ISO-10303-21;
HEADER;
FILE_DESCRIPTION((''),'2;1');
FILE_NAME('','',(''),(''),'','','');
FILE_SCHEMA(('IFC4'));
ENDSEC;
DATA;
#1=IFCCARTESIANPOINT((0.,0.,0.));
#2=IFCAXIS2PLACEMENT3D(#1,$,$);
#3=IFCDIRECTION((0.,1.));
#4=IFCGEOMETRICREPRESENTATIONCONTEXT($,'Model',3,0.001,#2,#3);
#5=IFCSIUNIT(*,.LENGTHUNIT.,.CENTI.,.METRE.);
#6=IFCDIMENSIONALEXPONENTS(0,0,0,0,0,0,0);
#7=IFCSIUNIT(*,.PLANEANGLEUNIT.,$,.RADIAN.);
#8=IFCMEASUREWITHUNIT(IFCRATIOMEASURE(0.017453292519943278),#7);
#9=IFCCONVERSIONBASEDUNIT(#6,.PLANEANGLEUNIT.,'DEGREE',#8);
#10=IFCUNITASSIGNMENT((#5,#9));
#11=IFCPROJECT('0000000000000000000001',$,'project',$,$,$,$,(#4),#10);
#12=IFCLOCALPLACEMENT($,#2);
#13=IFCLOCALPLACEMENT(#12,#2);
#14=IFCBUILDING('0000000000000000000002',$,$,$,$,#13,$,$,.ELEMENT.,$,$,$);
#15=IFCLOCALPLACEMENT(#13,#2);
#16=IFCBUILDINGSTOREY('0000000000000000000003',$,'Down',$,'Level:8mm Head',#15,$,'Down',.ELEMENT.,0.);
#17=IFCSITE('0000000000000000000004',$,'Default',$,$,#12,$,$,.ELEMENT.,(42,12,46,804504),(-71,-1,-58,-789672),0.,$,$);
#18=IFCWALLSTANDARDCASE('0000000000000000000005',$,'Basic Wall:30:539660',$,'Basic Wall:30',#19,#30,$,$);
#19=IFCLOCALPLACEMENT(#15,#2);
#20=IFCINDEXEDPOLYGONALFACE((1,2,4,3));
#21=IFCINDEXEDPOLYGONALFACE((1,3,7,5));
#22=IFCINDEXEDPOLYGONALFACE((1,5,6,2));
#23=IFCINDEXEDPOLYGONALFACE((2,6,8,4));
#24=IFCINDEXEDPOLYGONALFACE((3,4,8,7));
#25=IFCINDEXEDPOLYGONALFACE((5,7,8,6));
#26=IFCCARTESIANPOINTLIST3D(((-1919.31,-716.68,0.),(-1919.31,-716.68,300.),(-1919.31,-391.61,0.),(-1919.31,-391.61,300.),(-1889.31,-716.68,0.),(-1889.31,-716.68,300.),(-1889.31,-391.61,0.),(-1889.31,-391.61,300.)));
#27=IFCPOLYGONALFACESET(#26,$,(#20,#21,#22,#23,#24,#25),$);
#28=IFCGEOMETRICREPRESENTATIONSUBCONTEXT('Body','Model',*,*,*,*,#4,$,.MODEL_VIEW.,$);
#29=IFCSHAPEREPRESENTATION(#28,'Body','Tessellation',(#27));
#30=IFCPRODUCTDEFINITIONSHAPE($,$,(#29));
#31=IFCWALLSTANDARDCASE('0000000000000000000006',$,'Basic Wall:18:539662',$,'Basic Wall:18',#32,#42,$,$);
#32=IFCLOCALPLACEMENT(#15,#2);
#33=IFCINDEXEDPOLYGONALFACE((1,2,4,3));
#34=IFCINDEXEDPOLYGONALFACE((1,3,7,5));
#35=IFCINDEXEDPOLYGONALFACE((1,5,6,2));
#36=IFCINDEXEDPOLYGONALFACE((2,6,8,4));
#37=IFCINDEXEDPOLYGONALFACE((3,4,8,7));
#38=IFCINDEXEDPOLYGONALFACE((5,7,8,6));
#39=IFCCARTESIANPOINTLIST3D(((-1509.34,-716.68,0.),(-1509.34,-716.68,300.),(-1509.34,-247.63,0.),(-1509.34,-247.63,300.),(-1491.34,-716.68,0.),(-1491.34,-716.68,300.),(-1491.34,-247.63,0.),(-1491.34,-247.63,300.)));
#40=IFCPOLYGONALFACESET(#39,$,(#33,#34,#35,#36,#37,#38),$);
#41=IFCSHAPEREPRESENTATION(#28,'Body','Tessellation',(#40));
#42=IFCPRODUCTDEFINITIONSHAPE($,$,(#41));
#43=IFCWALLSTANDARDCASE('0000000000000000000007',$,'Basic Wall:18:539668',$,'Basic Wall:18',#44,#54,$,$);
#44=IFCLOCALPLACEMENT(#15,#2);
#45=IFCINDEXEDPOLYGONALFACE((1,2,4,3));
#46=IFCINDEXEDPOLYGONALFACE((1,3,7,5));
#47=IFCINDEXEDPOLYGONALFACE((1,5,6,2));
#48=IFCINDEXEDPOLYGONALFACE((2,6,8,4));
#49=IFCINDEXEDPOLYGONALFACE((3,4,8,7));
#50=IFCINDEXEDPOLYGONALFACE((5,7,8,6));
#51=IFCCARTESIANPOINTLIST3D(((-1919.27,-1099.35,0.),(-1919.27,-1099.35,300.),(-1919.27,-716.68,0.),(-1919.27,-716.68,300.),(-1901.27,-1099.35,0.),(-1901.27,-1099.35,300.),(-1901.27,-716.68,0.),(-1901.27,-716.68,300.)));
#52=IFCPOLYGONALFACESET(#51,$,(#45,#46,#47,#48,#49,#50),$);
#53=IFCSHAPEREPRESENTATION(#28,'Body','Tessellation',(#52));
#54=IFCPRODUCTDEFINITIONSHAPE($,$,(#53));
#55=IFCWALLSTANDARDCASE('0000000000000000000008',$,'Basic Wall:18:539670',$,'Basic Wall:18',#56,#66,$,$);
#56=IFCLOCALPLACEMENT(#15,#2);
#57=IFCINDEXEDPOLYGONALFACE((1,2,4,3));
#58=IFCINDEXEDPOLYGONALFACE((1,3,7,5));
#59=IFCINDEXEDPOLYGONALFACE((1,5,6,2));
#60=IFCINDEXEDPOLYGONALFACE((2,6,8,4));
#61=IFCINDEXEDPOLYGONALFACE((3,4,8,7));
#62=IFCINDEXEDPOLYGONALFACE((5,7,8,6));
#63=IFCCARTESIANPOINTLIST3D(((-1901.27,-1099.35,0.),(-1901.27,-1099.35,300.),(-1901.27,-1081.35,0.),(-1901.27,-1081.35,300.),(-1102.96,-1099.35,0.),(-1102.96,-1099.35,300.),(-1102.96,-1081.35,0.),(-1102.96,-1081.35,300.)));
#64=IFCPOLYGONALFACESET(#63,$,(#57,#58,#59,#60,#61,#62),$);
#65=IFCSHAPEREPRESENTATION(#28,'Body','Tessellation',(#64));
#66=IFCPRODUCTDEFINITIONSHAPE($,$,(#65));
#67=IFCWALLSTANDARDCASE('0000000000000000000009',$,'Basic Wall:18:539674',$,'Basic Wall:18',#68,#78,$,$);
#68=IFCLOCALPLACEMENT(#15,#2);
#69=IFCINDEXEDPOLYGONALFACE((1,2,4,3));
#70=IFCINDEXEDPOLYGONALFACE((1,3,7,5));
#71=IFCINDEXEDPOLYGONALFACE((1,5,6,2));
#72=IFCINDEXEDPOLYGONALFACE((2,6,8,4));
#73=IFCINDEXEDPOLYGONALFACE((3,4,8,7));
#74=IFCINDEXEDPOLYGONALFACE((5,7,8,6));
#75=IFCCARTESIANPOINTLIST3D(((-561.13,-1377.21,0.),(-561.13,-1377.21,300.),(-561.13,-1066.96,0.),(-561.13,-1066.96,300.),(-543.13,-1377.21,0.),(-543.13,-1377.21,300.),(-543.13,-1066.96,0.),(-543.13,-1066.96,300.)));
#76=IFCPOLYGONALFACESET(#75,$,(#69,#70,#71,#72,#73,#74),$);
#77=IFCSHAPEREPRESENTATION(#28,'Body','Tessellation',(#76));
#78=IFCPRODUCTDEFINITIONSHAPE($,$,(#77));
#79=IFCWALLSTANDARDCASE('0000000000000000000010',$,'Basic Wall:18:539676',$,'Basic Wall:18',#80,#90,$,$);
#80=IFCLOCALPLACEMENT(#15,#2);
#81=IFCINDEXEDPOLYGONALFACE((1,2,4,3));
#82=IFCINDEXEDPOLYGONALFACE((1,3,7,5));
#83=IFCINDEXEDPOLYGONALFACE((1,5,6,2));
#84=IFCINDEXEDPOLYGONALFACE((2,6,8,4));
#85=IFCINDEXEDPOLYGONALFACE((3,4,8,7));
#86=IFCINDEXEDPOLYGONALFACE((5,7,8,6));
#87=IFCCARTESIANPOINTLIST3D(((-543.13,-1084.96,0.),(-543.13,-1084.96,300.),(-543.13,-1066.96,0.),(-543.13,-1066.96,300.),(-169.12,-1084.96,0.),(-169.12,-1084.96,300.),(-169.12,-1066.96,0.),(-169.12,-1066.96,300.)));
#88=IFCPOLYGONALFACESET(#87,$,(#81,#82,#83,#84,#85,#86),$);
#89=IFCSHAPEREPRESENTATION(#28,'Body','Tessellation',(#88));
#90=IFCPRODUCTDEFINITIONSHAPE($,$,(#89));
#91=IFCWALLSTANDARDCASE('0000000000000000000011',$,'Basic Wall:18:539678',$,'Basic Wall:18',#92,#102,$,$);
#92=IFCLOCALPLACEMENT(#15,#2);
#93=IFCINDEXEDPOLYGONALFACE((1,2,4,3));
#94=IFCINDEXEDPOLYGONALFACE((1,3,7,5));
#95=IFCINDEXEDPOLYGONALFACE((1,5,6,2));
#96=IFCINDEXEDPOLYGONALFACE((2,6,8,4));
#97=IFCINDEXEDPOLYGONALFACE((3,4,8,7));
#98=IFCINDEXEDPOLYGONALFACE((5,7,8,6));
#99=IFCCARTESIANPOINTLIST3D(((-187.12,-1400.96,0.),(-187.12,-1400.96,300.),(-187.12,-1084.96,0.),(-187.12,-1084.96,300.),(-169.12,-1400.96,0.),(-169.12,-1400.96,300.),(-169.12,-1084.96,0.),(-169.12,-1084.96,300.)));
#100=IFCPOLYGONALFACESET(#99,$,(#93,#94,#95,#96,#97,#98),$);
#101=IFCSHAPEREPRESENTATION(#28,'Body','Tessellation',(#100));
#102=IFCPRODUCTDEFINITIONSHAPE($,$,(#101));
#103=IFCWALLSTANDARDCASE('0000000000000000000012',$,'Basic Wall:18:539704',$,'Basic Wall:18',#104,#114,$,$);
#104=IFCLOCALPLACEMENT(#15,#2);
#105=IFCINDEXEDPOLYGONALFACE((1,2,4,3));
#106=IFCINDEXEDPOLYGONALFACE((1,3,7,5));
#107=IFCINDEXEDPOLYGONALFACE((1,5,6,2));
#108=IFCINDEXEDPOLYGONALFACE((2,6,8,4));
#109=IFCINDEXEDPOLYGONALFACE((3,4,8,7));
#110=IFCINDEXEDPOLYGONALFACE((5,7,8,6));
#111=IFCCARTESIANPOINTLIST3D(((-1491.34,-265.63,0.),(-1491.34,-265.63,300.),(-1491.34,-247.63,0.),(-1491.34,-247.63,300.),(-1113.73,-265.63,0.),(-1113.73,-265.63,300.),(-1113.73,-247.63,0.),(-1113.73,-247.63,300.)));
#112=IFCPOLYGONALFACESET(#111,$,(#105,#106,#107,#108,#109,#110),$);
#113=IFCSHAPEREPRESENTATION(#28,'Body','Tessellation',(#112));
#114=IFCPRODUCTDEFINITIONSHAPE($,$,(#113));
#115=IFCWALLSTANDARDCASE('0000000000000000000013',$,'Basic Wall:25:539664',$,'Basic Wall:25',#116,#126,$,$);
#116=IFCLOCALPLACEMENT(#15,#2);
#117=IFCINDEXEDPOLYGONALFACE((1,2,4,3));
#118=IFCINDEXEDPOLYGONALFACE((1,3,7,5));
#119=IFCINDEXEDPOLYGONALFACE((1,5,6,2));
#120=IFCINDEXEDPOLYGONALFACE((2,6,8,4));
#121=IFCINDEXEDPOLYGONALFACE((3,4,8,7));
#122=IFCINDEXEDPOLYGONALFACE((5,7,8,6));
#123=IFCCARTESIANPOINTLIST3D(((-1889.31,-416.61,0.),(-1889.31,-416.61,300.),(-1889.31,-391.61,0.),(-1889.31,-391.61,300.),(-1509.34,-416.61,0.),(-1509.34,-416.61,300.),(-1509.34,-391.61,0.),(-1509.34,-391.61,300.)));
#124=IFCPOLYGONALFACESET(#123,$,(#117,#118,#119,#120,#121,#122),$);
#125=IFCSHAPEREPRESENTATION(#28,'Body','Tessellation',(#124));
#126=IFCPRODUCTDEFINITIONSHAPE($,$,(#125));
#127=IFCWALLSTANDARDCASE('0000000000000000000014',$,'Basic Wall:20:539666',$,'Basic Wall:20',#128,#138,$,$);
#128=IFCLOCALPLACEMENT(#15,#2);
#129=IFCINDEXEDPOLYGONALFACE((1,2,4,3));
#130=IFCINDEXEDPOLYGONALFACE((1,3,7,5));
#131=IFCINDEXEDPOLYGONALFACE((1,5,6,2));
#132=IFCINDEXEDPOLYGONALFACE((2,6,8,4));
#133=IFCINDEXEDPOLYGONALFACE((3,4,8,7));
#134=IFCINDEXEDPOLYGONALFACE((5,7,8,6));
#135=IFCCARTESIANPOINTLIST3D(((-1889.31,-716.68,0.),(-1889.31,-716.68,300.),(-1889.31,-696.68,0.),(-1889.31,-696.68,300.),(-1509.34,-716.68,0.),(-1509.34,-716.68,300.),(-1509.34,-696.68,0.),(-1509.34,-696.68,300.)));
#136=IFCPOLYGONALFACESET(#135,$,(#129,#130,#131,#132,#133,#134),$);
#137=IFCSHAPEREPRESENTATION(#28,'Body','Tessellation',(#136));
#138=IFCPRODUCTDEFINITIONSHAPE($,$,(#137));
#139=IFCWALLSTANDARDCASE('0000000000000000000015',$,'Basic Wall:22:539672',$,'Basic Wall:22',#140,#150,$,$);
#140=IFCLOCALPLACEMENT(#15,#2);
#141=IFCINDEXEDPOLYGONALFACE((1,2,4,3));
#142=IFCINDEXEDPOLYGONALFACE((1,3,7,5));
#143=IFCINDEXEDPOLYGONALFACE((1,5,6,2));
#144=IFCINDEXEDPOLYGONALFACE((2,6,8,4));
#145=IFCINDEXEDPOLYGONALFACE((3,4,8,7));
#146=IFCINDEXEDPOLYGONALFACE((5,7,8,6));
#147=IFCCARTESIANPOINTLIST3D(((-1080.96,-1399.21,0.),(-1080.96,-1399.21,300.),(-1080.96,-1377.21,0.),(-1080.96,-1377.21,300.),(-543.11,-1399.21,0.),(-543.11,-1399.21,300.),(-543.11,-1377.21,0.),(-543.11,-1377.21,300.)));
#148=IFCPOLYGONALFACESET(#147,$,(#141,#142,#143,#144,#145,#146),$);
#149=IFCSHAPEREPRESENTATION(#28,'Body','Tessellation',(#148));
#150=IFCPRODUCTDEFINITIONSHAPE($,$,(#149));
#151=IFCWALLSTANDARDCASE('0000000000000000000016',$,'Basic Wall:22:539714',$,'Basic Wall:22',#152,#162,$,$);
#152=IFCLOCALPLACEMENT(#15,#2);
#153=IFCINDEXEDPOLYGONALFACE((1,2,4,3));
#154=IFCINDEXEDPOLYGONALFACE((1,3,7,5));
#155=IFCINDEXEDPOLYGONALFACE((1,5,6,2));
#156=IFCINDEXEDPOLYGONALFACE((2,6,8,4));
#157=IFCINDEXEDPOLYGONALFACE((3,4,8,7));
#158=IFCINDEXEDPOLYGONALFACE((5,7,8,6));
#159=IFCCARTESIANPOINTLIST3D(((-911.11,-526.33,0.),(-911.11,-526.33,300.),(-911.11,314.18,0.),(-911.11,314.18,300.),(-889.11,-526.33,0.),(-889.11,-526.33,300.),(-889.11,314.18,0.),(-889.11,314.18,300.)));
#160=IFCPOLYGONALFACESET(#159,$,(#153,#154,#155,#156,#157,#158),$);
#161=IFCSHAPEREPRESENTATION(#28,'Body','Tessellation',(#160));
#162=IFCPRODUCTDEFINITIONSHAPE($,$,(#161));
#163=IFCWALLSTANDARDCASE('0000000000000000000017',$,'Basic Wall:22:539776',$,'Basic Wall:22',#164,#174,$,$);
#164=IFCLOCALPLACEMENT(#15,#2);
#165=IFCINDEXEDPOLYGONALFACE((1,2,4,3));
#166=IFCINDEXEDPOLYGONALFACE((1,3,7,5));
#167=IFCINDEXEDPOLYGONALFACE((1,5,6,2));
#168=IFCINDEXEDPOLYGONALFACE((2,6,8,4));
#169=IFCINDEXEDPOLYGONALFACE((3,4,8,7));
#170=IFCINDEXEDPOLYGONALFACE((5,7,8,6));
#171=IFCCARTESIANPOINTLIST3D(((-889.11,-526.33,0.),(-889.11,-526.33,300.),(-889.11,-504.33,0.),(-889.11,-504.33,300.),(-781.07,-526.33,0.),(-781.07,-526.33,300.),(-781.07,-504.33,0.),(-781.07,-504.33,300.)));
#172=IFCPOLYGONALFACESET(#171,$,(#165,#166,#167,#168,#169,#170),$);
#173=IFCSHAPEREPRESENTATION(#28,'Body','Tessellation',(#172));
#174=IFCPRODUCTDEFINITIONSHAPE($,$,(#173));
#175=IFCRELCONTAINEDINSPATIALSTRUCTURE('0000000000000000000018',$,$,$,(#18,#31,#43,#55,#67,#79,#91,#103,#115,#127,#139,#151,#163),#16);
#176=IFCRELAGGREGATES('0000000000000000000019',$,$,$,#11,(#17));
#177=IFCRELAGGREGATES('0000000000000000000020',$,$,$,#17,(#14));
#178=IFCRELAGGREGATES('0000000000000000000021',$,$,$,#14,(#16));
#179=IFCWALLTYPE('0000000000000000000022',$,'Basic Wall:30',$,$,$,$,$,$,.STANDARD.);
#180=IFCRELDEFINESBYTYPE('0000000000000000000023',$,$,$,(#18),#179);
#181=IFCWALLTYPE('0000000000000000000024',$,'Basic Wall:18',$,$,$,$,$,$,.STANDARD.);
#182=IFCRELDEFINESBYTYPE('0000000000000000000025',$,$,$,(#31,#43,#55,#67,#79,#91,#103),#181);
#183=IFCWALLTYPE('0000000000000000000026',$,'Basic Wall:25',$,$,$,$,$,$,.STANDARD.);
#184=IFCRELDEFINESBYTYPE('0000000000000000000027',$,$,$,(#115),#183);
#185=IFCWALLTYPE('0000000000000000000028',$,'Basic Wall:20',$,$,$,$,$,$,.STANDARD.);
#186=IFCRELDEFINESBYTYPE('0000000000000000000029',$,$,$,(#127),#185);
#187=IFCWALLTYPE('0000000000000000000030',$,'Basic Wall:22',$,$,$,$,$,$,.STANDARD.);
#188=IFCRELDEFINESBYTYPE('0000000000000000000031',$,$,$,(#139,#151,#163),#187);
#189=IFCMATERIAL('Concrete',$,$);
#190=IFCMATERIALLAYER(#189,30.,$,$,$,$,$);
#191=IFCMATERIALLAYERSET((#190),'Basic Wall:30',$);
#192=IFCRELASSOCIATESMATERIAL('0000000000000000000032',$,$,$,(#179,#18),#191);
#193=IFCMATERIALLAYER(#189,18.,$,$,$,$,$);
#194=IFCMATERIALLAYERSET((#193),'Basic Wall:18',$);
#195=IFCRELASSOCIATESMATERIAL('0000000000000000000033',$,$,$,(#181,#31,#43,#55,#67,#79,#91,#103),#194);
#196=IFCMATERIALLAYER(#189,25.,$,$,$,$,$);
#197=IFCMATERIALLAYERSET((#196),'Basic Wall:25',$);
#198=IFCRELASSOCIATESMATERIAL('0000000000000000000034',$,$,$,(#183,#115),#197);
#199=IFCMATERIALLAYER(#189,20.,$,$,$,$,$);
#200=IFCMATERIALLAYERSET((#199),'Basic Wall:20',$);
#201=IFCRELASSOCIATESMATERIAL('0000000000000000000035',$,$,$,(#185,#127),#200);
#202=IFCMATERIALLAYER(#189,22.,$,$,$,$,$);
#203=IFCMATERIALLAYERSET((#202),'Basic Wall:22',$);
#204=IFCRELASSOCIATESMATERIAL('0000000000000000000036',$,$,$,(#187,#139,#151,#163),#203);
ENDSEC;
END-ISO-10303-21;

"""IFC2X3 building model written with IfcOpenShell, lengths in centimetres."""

from ifc_helpers import new_model, entity, si_unit, converted_unit, direction, frame, frame_2d, origin, place, context, subcontext, project, spatial, rectangle, extrude, material, layer, layer_set, layer_usage, type_object, element, save


model = new_model("IFC2X3")

# Units and contexts
model_context = context("Model", 3, precision=0.001, world=origin(), true_north=direction((0.0, 1.0)))
body_context = subcontext(model_context, "Body", "Model", "MODEL_VIEW")
ifc_project = project(units=[si_unit("LENGTHUNIT", "METRE", prefix="CENTI"), converted_unit("PLANEANGLEUNIT", "DEGREE", entity("IfcRatioMeasure", 0.017453292519943278), si_unit("PLANEANGLEUNIT", "RADIAN"), dimensions=[0, 0, 0, 0, 0, 0, 0])], contexts=[model_context])

# Site, building, storey
site_placement = place(None, origin())
site = spatial("IfcSite", under=ifc_project, at=site_placement, Name="Default", CompositionType="ELEMENT", RefLatitude=(42, 12, 46, 804504), RefLongitude=(-71, -1, -58, -789672), RefElevation=0.0)
building_placement = place(site_placement, origin())
building = spatial("IfcBuilding", under=site, at=building_placement, CompositionType="ELEMENT")
storey_placement = place(building_placement, origin())
storey = spatial("IfcBuildingStorey", under=building, at=storey_placement, Name="Down", ObjectType="Level:8mm Head", LongName="Down", CompositionType="ELEMENT", Elevation=0.0)

# Walls
ifc_material = material(Name="Concrete")
ifc_layer_1 = layer(ifc_material, 30.0)
ifc_layer_set_1 = layer_set([ifc_layer_1], Name="Basic Wall:30")
ifc_layer_usage_1 = layer_usage(ifc_layer_set_1, "AXIS2", "POSITIVE", -15.0)
wall_type_1 = type_object("IfcWallType", Name="Basic Wall:30", PredefinedType="STANDARD", material=ifc_layer_set_1)
wall_1_placement = place(storey_placement, frame((-1904.31, -391.61, 0.0), z_axis=(0.0, 0.0, 1.0), x_axis=(0.0, -1.0, 0.0)))
element("IfcWallStandardCase", 1, at=wall_1_placement, inside=storey, type_object=wall_type_1, material=ifc_layer_usage_1, Name="Basic Wall:30:539660", ObjectType="Basic Wall:30", context=body_context, shape_type="SweptSolid", body=[
    extrude(rectangle(XDim=325.07, YDim=30.0, at=frame_2d((162.53, 0.0), x_axis=(-1.0, 0.0))), origin(), (0.0, 0.0, 1.0), 300.0),
])
ifc_layer_2 = layer(ifc_material, 18.0)
ifc_layer_set_2 = layer_set([ifc_layer_2], Name="Basic Wall:18")
ifc_layer_usage_2 = layer_usage(ifc_layer_set_2, "AXIS2", "NEGATIVE", 9.0)
wall_type_2 = type_object("IfcWallType", Name="Basic Wall:18", PredefinedType="STANDARD", material=ifc_layer_set_2)
wall_2_placement = place(storey_placement, frame((-1500.34, -247.63, 0.0), z_axis=(0.0, 0.0, 1.0), x_axis=(0.0, -1.0, 0.0)))
element("IfcWallStandardCase", 2, at=wall_2_placement, inside=storey, type_object=wall_type_2, material=ifc_layer_usage_2, Name="Basic Wall:18:539662", ObjectType="Basic Wall:18", context=body_context, shape_type="SweptSolid", body=[
    extrude(rectangle(XDim=469.05, YDim=18.0, at=frame_2d((234.53, 0.0), x_axis=(-1.0, 0.0))), origin(), (0.0, 0.0, 1.0), 300.0),
])
ifc_layer_usage_3 = layer_usage(ifc_layer_set_2, "AXIS2", "POSITIVE", -9.0)
wall_3_placement = place(storey_placement, frame((-1910.27, -716.68, 0.0), z_axis=(0.0, 0.0, 1.0), x_axis=(0.0, -1.0, 0.0)))
element("IfcWallStandardCase", 3, at=wall_3_placement, inside=storey, type_object=wall_type_2, material=ifc_layer_usage_3, Name="Basic Wall:18:539668", ObjectType="Basic Wall:18", context=body_context, shape_type="SweptSolid", body=[
    extrude(rectangle(XDim=382.66, YDim=18.0, at=frame_2d((191.33, 0.0), x_axis=(-1.0, 0.0))), origin(), (0.0, 0.0, 1.0), 300.0),
])
ifc_layer_usage_4 = layer_usage(ifc_layer_set_2, "AXIS2", "NEGATIVE", 9.0)
wall_4_placement = place(storey_placement, frame((-1901.27, -1090.35, 0.0)))
element("IfcWallStandardCase", 4, at=wall_4_placement, inside=storey, type_object=wall_type_2, material=ifc_layer_usage_4, Name="Basic Wall:18:539670", ObjectType="Basic Wall:18", context=body_context, shape_type="SweptSolid", body=[
    extrude(rectangle(XDim=798.31, YDim=18.0, at=frame_2d((399.16, 0.0), x_axis=(-1.0, 0.0))), origin(), (0.0, 0.0, 1.0), 300.0),
])
ifc_layer_usage_5 = layer_usage(ifc_layer_set_2, "AXIS2", "NEGATIVE", 9.0)
wall_5_placement = place(storey_placement, frame((-552.13, -1066.96, 0.0), z_axis=(0.0, 0.0, 1.0), x_axis=(0.0, -1.0, 0.0)))
element("IfcWallStandardCase", 5, at=wall_5_placement, inside=storey, type_object=wall_type_2, material=ifc_layer_usage_5, Name="Basic Wall:18:539674", ObjectType="Basic Wall:18", context=body_context, shape_type="SweptSolid", body=[
    extrude(rectangle(XDim=310.25, YDim=18.0, at=frame_2d((155.12, 0.0), x_axis=(-1.0, 0.0))), origin(), (0.0, 0.0, 1.0), 300.0),
])
ifc_layer_usage_6 = layer_usage(ifc_layer_set_2, "AXIS2", "POSITIVE", -9.0)
wall_6_placement = place(storey_placement, frame((-543.13, -1075.96, 0.0)))
element("IfcWallStandardCase", 6, at=wall_6_placement, inside=storey, type_object=wall_type_2, material=ifc_layer_usage_6, Name="Basic Wall:18:539676", ObjectType="Basic Wall:18", context=body_context, shape_type="SweptSolid", body=[
    extrude(rectangle(XDim=374.01, YDim=18.0, at=frame_2d((187.01, 0.0), x_axis=(-1.0, 0.0))), origin(), (0.0, 0.0, 1.0), 300.0),
])
ifc_layer_usage_7 = layer_usage(ifc_layer_set_2, "AXIS2", "POSITIVE", -9.0)
wall_7_placement = place(storey_placement, frame((-178.12, -1084.96, 0.0), z_axis=(0.0, 0.0, 1.0), x_axis=(0.0, -1.0, 0.0)))
element("IfcWallStandardCase", 7, at=wall_7_placement, inside=storey, type_object=wall_type_2, material=ifc_layer_usage_7, Name="Basic Wall:18:539678", ObjectType="Basic Wall:18", context=body_context, shape_type="SweptSolid", body=[
    extrude(rectangle(XDim=316.0, YDim=18.0, at=frame_2d((158.0, 0.0), x_axis=(-1.0, 0.0))), origin(), (0.0, 0.0, 1.0), 300.0),
])
ifc_layer_usage_8 = layer_usage(ifc_layer_set_2, "AXIS2", "POSITIVE", -9.0)
wall_8_placement = place(storey_placement, frame((-1491.34, -256.63, 0.0)))
element("IfcWallStandardCase", 8, at=wall_8_placement, inside=storey, type_object=wall_type_2, material=ifc_layer_usage_8, Name="Basic Wall:18:539704", ObjectType="Basic Wall:18", context=body_context, shape_type="SweptSolid", body=[
    extrude(rectangle(XDim=377.6, YDim=18.0, at=frame_2d((188.8, 0.0), x_axis=(-1.0, 0.0))), origin(), (0.0, 0.0, 1.0), 300.0),
])
ifc_layer_3 = layer(ifc_material, 25.0)
ifc_layer_set_3 = layer_set([ifc_layer_3], Name="Basic Wall:25")
ifc_layer_usage_9 = layer_usage(ifc_layer_set_3, "AXIS2", "NEGATIVE", 12.5)
wall_type_3 = type_object("IfcWallType", Name="Basic Wall:25", PredefinedType="STANDARD", material=ifc_layer_set_3)
wall_9_placement = place(storey_placement, frame((-1509.34, -404.11, 0.0), z_axis=(0.0, 0.0, 1.0), x_axis=(-1.0, 0.0, 0.0)))
element("IfcWallStandardCase", 9, at=wall_9_placement, inside=storey, type_object=wall_type_3, material=ifc_layer_usage_9, Name="Basic Wall:25:539664", ObjectType="Basic Wall:25", context=body_context, shape_type="SweptSolid", body=[
    extrude(rectangle(XDim=379.97, YDim=25.0, at=frame_2d((189.98, 0.0), x_axis=(-1.0, 0.0))), origin(), (0.0, 0.0, 1.0), 300.0),
])
ifc_layer_4 = layer(ifc_material, 20.0)
ifc_layer_set_4 = layer_set([ifc_layer_4], Name="Basic Wall:20")
ifc_layer_usage_10 = layer_usage(ifc_layer_set_4, "AXIS2", "POSITIVE", -10.0)
wall_type_4 = type_object("IfcWallType", Name="Basic Wall:20", PredefinedType="STANDARD", material=ifc_layer_set_4)
wall_10_placement = place(storey_placement, frame((-1509.34, -706.68, 0.0), z_axis=(0.0, 0.0, 1.0), x_axis=(-1.0, 0.0, 0.0)))
element("IfcWallStandardCase", 10, at=wall_10_placement, inside=storey, type_object=wall_type_4, material=ifc_layer_usage_10, Name="Basic Wall:20:539666", ObjectType="Basic Wall:20", context=body_context, shape_type="SweptSolid", body=[
    extrude(rectangle(XDim=379.97, YDim=20.0, at=frame_2d((189.98, 0.0), x_axis=(-1.0, 0.0))), origin(), (0.0, 0.0, 1.0), 300.0),
])
ifc_layer_5 = layer(ifc_material, 22.0)
ifc_layer_set_5 = layer_set([ifc_layer_5], Name="Basic Wall:22")
ifc_layer_usage_11 = layer_usage(ifc_layer_set_5, "AXIS2", "NEGATIVE", 11.0)
wall_type_5 = type_object("IfcWallType", Name="Basic Wall:22", PredefinedType="STANDARD", material=ifc_layer_set_5)
wall_11_placement = place(storey_placement, frame((-1080.96, -1388.21, 0.0)))
element("IfcWallStandardCase", 11, at=wall_11_placement, inside=storey, type_object=wall_type_5, material=ifc_layer_usage_11, Name="Basic Wall:22:539672", ObjectType="Basic Wall:22", context=body_context, shape_type="SweptSolid", body=[
    extrude(rectangle(XDim=537.86, YDim=22.0, at=frame_2d((268.93, 0.0), x_axis=(-1.0, 0.0))), origin(), (0.0, 0.0, 1.0), 300.0),
])
ifc_layer_usage_12 = layer_usage(ifc_layer_set_5, "AXIS2", "POSITIVE", -11.0)
wall_12_placement = place(storey_placement, frame((-900.11, -526.33, 0.0), z_axis=(0.0, 0.0, 1.0), x_axis=(0.0, 1.0, 0.0)))
element("IfcWallStandardCase", 12, at=wall_12_placement, inside=storey, type_object=wall_type_5, material=ifc_layer_usage_12, Name="Basic Wall:22:539714", ObjectType="Basic Wall:22", context=body_context, shape_type="SweptSolid", body=[
    extrude(rectangle(XDim=840.52, YDim=22.0, at=frame_2d((420.26, 0.0), x_axis=(-1.0, 0.0))), origin(), (0.0, 0.0, 1.0), 300.0),
])
ifc_layer_usage_13 = layer_usage(ifc_layer_set_5, "AXIS2", "NEGATIVE", 11.0)
wall_13_placement = place(storey_placement, frame((-781.07, -515.33, 0.0), z_axis=(0.0, 0.0, 1.0), x_axis=(-1.0, 0.0, 0.0)))
element("IfcWallStandardCase", 13, at=wall_13_placement, inside=storey, type_object=wall_type_5, material=ifc_layer_usage_13, Name="Basic Wall:22:539776", ObjectType="Basic Wall:22", context=body_context, shape_type="SweptSolid", body=[
    extrude(rectangle(XDim=108.04, YDim=22.0, at=frame_2d((54.02, 0.0), x_axis=(-1.0, 0.0))), origin(), (0.0, 0.0, 1.0), 300.0),
])

save(model, "model.ifc")
